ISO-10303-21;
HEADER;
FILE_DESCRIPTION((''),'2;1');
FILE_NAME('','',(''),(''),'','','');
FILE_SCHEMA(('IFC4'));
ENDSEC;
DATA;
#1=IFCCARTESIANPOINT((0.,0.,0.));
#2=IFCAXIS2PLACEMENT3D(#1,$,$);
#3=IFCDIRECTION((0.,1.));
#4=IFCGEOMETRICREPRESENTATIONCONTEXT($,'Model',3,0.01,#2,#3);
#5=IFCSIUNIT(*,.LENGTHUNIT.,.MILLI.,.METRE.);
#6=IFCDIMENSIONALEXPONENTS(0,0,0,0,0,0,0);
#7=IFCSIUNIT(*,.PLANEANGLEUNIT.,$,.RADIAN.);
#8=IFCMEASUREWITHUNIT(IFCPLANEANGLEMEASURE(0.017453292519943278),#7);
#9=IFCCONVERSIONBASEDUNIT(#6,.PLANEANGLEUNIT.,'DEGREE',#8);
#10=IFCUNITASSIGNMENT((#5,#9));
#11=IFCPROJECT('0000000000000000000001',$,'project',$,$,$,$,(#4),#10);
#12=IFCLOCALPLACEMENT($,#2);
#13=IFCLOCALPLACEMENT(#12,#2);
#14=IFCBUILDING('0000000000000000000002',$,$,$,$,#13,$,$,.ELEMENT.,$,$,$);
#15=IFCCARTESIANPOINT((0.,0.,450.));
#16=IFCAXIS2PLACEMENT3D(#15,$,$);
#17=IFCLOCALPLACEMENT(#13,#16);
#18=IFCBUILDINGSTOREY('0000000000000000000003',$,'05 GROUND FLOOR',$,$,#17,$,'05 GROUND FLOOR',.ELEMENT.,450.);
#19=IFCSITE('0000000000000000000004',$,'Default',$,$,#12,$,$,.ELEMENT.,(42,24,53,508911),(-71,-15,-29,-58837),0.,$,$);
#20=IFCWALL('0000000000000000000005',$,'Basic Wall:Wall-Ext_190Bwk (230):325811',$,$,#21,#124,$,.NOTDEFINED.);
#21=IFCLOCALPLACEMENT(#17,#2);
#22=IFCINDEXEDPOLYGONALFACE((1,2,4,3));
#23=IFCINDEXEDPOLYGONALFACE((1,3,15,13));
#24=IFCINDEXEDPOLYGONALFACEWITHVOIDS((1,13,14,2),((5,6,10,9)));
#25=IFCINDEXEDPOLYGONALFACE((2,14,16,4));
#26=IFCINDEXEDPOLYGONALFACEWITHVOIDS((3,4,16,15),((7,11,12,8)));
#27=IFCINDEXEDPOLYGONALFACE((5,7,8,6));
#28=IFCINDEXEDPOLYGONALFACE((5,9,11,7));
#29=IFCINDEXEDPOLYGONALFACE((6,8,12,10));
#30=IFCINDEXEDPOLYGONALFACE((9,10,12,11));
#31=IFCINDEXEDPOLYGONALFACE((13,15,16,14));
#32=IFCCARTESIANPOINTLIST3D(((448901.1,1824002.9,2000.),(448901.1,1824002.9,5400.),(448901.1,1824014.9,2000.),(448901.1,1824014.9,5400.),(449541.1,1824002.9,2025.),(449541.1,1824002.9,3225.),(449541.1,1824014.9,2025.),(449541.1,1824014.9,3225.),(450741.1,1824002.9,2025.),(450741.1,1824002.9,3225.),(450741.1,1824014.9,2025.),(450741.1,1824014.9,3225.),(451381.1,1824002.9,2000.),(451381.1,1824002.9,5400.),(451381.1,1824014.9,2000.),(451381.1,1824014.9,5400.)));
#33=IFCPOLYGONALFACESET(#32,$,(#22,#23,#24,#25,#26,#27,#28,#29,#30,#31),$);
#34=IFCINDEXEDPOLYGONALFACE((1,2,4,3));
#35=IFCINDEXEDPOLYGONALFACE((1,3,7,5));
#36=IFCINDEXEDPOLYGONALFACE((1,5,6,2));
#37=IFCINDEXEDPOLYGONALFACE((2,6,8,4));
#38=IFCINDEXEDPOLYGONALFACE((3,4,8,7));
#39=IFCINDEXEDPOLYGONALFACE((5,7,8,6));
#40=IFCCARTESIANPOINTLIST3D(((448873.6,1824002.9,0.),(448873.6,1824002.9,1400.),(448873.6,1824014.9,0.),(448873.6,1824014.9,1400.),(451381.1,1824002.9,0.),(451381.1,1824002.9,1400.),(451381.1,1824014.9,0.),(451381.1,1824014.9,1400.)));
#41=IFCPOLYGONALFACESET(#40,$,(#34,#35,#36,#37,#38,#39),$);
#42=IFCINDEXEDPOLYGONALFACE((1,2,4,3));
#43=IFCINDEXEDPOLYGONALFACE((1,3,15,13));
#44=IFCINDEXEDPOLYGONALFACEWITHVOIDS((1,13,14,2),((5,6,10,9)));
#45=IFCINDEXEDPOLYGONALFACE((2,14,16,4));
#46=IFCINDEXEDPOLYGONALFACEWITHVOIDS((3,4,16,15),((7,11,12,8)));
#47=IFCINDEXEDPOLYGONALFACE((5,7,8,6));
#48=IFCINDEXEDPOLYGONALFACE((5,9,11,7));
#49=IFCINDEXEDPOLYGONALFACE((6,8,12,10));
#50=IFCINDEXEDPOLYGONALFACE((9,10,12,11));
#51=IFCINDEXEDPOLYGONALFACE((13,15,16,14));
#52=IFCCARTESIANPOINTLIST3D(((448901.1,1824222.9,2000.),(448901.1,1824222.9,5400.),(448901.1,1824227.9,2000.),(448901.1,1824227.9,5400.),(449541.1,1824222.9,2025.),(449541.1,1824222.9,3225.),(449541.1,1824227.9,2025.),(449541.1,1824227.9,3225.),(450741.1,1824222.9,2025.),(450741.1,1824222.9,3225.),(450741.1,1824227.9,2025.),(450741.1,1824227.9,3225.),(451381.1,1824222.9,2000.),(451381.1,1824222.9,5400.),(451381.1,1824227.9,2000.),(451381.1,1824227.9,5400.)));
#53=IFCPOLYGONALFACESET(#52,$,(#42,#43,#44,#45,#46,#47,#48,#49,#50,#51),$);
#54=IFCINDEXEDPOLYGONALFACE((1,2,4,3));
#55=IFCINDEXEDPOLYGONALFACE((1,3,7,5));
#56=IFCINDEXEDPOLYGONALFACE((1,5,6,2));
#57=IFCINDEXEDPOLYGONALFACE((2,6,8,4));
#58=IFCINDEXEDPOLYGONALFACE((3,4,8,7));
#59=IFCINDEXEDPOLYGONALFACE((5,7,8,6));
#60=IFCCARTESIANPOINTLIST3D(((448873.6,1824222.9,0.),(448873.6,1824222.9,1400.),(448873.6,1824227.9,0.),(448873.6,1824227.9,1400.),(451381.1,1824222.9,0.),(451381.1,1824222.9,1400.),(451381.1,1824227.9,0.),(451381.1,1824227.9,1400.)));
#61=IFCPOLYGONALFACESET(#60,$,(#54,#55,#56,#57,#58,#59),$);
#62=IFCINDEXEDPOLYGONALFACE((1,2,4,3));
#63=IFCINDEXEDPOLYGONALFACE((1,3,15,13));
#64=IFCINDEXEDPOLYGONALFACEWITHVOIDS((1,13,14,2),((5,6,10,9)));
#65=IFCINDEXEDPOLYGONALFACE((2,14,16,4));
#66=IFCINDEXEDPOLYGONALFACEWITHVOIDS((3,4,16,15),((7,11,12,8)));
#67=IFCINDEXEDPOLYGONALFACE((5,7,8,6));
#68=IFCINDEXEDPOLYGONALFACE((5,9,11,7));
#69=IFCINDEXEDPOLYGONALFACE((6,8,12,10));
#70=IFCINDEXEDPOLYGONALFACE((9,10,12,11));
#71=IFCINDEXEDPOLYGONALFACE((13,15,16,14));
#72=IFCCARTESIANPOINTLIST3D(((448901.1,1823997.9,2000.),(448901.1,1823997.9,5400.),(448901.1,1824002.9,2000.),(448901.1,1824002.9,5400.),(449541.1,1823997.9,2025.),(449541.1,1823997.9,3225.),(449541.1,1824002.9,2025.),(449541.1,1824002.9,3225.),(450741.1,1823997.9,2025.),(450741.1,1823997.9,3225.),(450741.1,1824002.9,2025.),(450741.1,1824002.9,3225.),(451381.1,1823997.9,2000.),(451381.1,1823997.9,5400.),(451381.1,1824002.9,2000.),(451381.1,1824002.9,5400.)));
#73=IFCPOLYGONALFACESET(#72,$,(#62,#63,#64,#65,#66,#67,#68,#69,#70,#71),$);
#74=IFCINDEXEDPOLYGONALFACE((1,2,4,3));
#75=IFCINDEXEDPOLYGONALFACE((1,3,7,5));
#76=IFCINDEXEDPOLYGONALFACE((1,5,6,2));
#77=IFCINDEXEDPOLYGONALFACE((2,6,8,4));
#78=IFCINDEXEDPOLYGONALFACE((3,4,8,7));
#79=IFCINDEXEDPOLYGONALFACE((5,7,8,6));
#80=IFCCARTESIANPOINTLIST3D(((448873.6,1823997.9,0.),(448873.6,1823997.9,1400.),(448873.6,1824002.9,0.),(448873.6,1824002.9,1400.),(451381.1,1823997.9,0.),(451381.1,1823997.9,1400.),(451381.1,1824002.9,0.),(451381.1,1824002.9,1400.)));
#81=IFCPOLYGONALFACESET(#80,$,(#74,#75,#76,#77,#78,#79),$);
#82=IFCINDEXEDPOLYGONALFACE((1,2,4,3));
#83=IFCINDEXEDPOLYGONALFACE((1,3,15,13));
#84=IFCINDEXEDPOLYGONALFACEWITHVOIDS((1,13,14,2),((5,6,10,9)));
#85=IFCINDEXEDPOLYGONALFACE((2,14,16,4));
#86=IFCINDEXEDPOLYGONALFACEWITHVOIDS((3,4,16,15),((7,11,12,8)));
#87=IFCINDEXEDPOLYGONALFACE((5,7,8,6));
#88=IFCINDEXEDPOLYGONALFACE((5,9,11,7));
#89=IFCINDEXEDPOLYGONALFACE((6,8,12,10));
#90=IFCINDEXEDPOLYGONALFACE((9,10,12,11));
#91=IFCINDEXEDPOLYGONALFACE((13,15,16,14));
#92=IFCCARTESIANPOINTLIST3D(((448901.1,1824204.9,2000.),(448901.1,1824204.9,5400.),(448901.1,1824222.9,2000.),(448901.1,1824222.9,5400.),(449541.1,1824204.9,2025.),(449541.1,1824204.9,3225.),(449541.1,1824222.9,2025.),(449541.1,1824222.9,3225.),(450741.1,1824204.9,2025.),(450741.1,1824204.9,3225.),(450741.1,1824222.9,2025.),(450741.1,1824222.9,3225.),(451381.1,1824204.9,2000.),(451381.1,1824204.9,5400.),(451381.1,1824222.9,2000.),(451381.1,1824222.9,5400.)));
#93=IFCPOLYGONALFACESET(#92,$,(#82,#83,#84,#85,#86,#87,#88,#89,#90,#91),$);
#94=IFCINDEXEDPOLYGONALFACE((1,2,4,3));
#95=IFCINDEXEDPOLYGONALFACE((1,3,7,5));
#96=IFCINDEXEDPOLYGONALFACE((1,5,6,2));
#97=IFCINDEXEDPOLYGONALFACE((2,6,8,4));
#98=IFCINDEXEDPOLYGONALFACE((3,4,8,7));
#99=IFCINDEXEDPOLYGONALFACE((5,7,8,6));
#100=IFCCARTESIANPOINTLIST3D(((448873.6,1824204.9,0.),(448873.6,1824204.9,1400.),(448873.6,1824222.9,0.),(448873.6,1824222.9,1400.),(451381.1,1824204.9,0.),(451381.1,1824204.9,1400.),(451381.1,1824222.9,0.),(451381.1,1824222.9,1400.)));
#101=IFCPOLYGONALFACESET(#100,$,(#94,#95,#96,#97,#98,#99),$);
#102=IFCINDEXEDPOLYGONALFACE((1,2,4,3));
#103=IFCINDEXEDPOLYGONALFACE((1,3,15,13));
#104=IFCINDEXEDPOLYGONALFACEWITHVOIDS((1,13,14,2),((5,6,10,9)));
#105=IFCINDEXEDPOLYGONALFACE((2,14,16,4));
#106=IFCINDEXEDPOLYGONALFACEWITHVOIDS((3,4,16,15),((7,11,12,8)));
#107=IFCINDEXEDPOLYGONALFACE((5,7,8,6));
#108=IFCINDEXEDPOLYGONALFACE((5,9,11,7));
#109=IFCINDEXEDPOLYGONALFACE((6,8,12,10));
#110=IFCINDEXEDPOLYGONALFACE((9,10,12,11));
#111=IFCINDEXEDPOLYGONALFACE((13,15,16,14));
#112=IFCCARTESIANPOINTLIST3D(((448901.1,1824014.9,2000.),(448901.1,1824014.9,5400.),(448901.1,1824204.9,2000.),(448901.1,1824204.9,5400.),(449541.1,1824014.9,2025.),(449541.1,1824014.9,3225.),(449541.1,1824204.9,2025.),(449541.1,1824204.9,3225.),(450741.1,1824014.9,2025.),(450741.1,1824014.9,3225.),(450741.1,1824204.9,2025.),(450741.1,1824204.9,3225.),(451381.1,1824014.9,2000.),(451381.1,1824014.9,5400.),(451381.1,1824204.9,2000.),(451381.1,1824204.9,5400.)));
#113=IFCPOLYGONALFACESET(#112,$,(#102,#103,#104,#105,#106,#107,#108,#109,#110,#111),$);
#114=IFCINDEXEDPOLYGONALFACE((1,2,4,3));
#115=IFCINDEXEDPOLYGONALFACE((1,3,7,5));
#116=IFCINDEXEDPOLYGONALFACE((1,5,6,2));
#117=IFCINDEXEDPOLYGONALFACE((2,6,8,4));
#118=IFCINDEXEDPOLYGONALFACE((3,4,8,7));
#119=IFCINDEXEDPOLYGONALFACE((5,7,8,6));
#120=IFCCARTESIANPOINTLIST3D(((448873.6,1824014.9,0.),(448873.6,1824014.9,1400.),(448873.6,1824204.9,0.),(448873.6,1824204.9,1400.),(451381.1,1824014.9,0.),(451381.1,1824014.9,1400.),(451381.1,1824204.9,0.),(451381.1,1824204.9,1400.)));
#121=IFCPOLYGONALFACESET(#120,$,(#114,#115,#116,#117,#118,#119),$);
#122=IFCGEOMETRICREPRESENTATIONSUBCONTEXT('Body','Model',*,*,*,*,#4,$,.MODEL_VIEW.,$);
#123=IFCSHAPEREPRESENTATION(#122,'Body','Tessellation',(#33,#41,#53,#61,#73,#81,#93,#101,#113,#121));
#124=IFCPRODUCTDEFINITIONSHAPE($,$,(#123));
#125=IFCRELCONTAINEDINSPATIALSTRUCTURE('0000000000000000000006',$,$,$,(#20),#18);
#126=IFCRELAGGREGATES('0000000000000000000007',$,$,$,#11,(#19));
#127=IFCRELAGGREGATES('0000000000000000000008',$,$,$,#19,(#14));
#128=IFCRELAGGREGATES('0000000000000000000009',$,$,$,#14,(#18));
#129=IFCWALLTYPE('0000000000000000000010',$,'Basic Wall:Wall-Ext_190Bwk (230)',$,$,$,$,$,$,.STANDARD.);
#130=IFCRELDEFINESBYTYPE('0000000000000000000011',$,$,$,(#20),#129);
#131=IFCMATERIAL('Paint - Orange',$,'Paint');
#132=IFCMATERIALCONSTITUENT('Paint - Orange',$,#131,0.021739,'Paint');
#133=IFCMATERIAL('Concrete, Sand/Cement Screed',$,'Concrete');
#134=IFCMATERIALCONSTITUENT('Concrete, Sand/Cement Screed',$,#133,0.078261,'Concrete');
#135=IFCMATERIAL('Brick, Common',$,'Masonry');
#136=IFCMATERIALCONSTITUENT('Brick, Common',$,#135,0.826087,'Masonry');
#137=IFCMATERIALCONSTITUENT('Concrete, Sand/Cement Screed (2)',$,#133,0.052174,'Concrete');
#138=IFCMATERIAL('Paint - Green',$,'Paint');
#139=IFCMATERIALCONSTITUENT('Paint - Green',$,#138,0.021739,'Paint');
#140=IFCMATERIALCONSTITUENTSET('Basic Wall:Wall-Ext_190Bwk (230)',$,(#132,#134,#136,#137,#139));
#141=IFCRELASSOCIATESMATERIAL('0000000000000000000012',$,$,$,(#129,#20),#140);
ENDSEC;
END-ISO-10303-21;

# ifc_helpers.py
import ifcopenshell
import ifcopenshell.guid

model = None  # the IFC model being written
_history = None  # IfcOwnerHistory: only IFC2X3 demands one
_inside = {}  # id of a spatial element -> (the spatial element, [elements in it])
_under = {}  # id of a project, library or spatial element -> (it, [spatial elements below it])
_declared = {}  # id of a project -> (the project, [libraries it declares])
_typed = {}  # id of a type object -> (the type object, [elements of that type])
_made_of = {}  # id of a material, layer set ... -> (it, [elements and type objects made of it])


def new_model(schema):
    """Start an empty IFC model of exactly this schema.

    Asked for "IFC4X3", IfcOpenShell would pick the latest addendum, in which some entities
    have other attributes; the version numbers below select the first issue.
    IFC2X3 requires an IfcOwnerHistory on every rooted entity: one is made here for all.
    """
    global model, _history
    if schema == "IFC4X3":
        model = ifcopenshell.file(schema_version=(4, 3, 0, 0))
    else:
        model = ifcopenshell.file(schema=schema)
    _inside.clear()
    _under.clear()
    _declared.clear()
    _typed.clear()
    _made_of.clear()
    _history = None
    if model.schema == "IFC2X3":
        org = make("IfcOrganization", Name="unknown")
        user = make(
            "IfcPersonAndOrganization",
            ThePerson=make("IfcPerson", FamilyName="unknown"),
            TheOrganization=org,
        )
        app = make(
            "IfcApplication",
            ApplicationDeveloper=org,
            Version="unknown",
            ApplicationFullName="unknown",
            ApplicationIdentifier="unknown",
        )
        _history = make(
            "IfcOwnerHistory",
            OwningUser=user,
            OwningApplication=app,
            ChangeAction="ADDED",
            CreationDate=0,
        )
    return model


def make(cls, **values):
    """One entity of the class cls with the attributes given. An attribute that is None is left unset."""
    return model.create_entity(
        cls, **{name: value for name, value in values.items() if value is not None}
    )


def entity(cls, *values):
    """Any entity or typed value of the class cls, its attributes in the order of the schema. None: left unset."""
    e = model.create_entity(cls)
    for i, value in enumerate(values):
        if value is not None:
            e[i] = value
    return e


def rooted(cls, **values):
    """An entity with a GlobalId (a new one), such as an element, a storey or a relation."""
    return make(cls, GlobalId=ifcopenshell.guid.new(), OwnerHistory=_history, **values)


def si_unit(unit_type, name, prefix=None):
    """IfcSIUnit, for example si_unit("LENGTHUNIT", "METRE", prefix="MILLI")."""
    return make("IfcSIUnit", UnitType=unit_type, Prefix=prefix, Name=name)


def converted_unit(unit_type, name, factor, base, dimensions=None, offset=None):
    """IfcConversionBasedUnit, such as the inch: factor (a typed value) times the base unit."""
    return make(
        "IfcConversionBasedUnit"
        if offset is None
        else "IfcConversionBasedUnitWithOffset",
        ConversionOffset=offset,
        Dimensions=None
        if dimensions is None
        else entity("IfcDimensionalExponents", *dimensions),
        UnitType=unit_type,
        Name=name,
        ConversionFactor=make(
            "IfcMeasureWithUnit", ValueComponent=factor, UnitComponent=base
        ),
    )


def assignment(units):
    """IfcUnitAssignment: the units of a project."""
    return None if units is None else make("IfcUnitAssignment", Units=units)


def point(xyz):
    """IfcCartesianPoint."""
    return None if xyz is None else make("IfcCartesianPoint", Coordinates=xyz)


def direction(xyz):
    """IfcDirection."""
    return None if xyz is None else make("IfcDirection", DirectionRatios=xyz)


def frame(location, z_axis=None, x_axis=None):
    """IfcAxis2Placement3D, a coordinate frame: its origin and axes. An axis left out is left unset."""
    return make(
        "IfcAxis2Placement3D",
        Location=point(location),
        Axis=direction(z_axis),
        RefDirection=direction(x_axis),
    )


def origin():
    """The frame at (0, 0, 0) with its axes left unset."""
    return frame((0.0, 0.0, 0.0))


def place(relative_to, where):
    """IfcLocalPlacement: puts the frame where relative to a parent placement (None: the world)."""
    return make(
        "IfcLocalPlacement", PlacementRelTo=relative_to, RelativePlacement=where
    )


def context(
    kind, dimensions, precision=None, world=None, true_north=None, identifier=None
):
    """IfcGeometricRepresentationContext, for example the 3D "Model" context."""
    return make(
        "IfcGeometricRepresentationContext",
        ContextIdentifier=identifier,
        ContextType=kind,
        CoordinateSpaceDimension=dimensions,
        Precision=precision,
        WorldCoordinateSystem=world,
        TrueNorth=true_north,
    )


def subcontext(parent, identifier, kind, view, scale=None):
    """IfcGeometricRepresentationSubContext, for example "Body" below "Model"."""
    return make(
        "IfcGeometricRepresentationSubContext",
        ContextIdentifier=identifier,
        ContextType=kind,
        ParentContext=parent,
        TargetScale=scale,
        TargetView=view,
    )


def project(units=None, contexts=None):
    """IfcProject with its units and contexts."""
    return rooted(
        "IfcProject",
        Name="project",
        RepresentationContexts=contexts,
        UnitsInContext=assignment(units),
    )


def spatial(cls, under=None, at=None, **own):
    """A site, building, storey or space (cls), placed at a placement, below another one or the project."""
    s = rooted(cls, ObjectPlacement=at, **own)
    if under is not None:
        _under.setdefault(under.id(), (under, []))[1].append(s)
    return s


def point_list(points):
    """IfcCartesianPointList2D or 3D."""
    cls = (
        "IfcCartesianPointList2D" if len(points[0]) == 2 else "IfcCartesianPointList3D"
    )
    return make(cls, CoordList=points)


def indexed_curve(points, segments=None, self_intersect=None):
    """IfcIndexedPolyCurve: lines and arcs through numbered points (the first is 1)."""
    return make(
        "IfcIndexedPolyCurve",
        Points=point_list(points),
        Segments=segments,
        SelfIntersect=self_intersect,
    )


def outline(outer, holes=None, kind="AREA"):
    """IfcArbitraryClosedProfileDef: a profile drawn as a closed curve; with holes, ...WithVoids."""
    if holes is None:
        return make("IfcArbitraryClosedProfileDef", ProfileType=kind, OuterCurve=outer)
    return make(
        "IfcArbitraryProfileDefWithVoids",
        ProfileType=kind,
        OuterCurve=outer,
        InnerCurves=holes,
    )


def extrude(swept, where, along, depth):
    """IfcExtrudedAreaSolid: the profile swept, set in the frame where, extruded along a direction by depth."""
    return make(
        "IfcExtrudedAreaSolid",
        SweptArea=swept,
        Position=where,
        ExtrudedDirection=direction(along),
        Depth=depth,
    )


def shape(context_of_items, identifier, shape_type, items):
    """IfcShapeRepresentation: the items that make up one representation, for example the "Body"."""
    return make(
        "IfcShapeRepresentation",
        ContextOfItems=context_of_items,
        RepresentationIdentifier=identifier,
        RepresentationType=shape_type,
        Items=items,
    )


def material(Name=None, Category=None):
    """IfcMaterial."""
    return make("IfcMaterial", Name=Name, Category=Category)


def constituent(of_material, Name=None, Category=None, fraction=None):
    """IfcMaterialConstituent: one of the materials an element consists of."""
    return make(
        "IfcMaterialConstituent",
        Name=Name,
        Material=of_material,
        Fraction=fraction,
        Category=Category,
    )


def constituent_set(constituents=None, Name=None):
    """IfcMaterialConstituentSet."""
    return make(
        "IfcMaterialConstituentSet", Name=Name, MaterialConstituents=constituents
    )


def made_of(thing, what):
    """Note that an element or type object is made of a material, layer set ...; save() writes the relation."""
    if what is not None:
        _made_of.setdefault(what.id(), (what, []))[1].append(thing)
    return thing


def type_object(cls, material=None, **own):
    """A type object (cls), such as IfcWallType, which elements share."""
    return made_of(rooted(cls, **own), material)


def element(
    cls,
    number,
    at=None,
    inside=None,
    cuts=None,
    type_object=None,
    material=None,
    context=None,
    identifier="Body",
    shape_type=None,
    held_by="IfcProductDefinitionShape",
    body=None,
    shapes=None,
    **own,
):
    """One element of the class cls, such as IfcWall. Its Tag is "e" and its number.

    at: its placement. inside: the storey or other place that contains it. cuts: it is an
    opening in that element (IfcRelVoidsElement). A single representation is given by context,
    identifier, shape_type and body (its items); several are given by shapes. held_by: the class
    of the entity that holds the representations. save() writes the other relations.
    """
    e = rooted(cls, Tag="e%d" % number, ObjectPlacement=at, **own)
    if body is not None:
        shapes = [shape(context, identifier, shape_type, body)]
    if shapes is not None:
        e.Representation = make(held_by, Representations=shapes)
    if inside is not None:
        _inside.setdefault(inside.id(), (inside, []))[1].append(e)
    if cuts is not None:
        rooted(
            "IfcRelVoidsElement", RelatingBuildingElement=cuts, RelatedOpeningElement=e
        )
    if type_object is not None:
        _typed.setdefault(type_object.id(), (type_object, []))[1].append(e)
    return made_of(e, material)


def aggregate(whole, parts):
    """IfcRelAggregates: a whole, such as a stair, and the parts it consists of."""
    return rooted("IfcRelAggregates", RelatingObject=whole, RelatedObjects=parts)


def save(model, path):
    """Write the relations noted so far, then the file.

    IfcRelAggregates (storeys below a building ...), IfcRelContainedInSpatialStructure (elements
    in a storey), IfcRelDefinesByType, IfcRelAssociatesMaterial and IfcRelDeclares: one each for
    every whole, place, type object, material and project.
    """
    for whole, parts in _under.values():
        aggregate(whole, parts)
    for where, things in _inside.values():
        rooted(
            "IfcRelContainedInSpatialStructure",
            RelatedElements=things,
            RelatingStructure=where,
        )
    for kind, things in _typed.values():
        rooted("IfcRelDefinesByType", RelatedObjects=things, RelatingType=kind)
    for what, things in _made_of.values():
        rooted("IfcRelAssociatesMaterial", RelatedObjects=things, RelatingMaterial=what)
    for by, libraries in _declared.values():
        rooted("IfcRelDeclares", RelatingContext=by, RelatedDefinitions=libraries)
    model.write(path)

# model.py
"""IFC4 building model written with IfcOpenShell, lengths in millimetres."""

from ifc_helpers import new_model, entity, si_unit, converted_unit, direction, frame, origin, place, context, subcontext, project, spatial, indexed_curve, outline, extrude, material, constituent, constituent_set, type_object, element, save


model = new_model("IFC4")

# Units and contexts
model_context = context("Model", 3, precision=0.01, world=origin(), true_north=direction((0.0, 1.0)))
body_context = subcontext(model_context, "Body", "Model", "MODEL_VIEW")
ifc_project = project(units=[si_unit("LENGTHUNIT", "METRE", prefix="MILLI"), converted_unit("PLANEANGLEUNIT", "DEGREE", entity("IfcPlaneAngleMeasure", 0.017453292519943278), si_unit("PLANEANGLEUNIT", "RADIAN"), dimensions=[0, 0, 0, 0, 0, 0, 0])], contexts=[model_context])

# Site, building, storey
site_placement = place(None, origin())
site = spatial("IfcSite", under=ifc_project, at=site_placement, Name="Default", CompositionType="ELEMENT", RefLatitude=(42, 24, 53, 508911), RefLongitude=(-71, -15, -29, -58837), RefElevation=0.0)
building_placement = place(site_placement, origin())
building = spatial("IfcBuilding", under=site, at=building_placement, CompositionType="ELEMENT")
storey_placement = place(building_placement, frame((0.0, 0.0, 450.0)))
storey = spatial("IfcBuildingStorey", under=building, at=storey_placement, Name="05 GROUND FLOOR", LongName="05 GROUND FLOOR", CompositionType="ELEMENT", Elevation=450.0)

# Shared definitions
ifc_material_1 = material(Name="Concrete, Sand/Cement Screed", Category="Concrete")
ifc_material_2 = material(Name="Brick, Common", Category="Masonry")

# Wall, opening
ifc_material_3 = material(Name="Paint - Orange", Category="Paint")
ifc_constituent_1 = constituent(ifc_material_3, Name="Paint - Orange", Category="Paint", fraction=0.021739)
ifc_constituent_2 = constituent(ifc_material_1, Name="Concrete, Sand/Cement Screed", Category="Concrete", fraction=0.078261)
ifc_constituent_3 = constituent(ifc_material_2, Name="Brick, Common", Category="Masonry", fraction=0.826087)
ifc_constituent_4 = constituent(ifc_material_1, Name="Concrete, Sand/Cement Screed (2)", Category="Concrete", fraction=0.052174)
ifc_material_4 = material(Name="Paint - Green", Category="Paint")
ifc_constituent_5 = constituent(ifc_material_4, Name="Paint - Green", Category="Paint", fraction=0.021739)
ifc_constituent_set_1 = constituent_set(constituents=[ifc_constituent_1, ifc_constituent_2, ifc_constituent_3, ifc_constituent_4, ifc_constituent_5], Name="Basic Wall:Wall-Ext_190Bwk (230)")
wall_type_1 = type_object("IfcWallType", Name="Basic Wall:Wall-Ext_190Bwk (230)", PredefinedType="STANDARD", material=ifc_constituent_set_1)
wall_1_placement = place(storey_placement, frame((448873.6, 1824112.9, 0.0)))
wall_1 = element("IfcWall", 1, at=wall_1_placement, inside=storey, type_object=wall_type_1, material=ifc_constituent_set_1, Name="Basic Wall:Wall-Ext_190Bwk (230):325811", PredefinedType="NOTDEFINED", context=body_context, shape_type="SweptSolid", body=[
    extrude(outline(indexed_curve([(-1700.0, -1240.0), (1700.0, -1240.0), (1700.0, 1240.0), (-1700.0, 1240.0), (-1700.0, -1240.0)], self_intersect=False), holes=[indexed_curve([(-1675.0, -600.0), (-1675.0, 600.0), (-475.0, 600.0), (-475.0, -600.0), (-1675.0, -600.0)], self_intersect=False)]), frame((1267.5, -110.0, 3700.0), z_axis=(0.0, 1.0, 0.0), x_axis=(0.0, 0.0, 1.0)), (0.0, 0.0, 1.0), 12.0),
    extrude(outline(indexed_curve([(-1253.8, -6.0), (1253.8, -6.0), (1253.8, 6.0), (-1253.8, 6.0), (-1253.8, -6.0)], self_intersect=False)), frame((1253.8, -104.0, 0.0)), (0.0, 0.0, 1.0), 1400.0),
    extrude(outline(indexed_curve([(-1700.0, -1240.0), (1700.0, -1240.0), (1700.0, 1240.0), (-1700.0, 1240.0), (-1700.0, -1240.0)], self_intersect=False), holes=[indexed_curve([(-1675.0, -600.0), (-1675.0, 600.0), (-475.0, 600.0), (-475.0, -600.0), (-1675.0, -600.0)], self_intersect=False)]), frame((1267.5, 110.0, 3700.0), z_axis=(0.0, 1.0, 0.0), x_axis=(0.0, 0.0, 1.0)), (0.0, 0.0, 1.0), 5.0),
    extrude(outline(indexed_curve([(-2.5, -1253.8), (2.5, -1253.8), (2.5, 1253.8), (-2.5, 1253.8), (-2.5, -1253.8)], self_intersect=False)), frame((1253.8, 112.5, 0.0), z_axis=(0.0, 0.0, 1.0), x_axis=(0.0, -1.0, 0.0)), (0.0, 0.0, 1.0), 1400.0),
    extrude(outline(indexed_curve([(-1700.0, -1240.0), (1700.0, -1240.0), (1700.0, 1240.0), (-1700.0, 1240.0), (-1700.0, -1240.0)], self_intersect=False), holes=[indexed_curve([(-475.0, -600.0), (-1675.0, -600.0), (-1675.0, 600.0), (-475.0, 600.0), (-475.0, -600.0)], self_intersect=False)]), frame((1267.5, -115.0, 3700.0), z_axis=(0.0, 1.0, 0.0), x_axis=(0.0, 0.0, 1.0)), (0.0, 0.0, 1.0), 5.0),
    extrude(outline(indexed_curve([(-2.5, -1253.8), (2.5, -1253.8), (2.5, 1253.8), (-2.5, 1253.8), (-2.5, -1253.8)], self_intersect=False)), frame((1253.8, -112.5, 0.0), z_axis=(0.0, 0.0, 1.0), x_axis=(0.0, 1.0, 0.0)), (0.0, 0.0, 1.0), 1400.0),
    extrude(outline(indexed_curve([(-1700.0, -1240.0), (1700.0, -1240.0), (1700.0, 1240.0), (-1700.0, 1240.0), (-1700.0, -1240.0)], self_intersect=False), holes=[indexed_curve([(-1675.0, -600.0), (-1675.0, 600.0), (-475.0, 600.0), (-475.0, -600.0), (-1675.0, -600.0)], self_intersect=False)]), frame((1267.5, 92.0, 3700.0), z_axis=(0.0, 1.0, 0.0), x_axis=(0.0, 0.0, 1.0)), (0.0, 0.0, 1.0), 18.0),
    extrude(outline(indexed_curve([(-1253.8, -9.0), (1253.8, -9.0), (1253.8, 9.0), (-1253.8, 9.0), (-1253.8, -9.0)], self_intersect=False)), frame((1253.8, 101.0, 0.0)), (0.0, 0.0, 1.0), 1400.0),
    extrude(outline(indexed_curve([(-1700.0, -1240.0), (1700.0, -1240.0), (1700.0, 1240.0), (-1700.0, 1240.0), (-1700.0, -1240.0)], self_intersect=False), holes=[indexed_curve([(-1675.0, -600.0), (-1675.0, 600.0), (-475.0, 600.0), (-475.0, -600.0), (-1675.0, -600.0)], self_intersect=False)]), frame((1267.5, -98.0, 3700.0), z_axis=(0.0, 1.0, 0.0), x_axis=(0.0, 0.0, 1.0)), (0.0, 0.0, 1.0), 190.0),
    extrude(outline(indexed_curve([(-1253.8, -95.0), (1253.8, -95.0), (1253.8, 95.0), (-1253.8, 95.0), (-1253.8, -95.0)], self_intersect=False)), frame((1253.8, -3.0, 0.0)), (0.0, 0.0, 1.0), 1400.0),
])
opening_1_placement = place(wall_1_placement, frame((1867.5, 115.0, 2025.0)))
element("IfcOpeningElement", 2, at=opening_1_placement, cuts=wall_1, PredefinedType="OPENING", context=body_context, shape_type="SweptSolid", body=[
    extrude(outline(indexed_curve([(1200.0, 1200.0), (0.0, 1200.0), (0.0, 0.0), (1200.0, 0.0), (1200.0, 1200.0)], self_intersect=False)), frame((0.0, 0.0, 0.0), z_axis=(0.0, -1.0, 0.0), x_axis=(0.0, 0.0, 1.0)), (0.0, 0.0, 1.0), 230.0),
])

save(model, "model.ifc")
